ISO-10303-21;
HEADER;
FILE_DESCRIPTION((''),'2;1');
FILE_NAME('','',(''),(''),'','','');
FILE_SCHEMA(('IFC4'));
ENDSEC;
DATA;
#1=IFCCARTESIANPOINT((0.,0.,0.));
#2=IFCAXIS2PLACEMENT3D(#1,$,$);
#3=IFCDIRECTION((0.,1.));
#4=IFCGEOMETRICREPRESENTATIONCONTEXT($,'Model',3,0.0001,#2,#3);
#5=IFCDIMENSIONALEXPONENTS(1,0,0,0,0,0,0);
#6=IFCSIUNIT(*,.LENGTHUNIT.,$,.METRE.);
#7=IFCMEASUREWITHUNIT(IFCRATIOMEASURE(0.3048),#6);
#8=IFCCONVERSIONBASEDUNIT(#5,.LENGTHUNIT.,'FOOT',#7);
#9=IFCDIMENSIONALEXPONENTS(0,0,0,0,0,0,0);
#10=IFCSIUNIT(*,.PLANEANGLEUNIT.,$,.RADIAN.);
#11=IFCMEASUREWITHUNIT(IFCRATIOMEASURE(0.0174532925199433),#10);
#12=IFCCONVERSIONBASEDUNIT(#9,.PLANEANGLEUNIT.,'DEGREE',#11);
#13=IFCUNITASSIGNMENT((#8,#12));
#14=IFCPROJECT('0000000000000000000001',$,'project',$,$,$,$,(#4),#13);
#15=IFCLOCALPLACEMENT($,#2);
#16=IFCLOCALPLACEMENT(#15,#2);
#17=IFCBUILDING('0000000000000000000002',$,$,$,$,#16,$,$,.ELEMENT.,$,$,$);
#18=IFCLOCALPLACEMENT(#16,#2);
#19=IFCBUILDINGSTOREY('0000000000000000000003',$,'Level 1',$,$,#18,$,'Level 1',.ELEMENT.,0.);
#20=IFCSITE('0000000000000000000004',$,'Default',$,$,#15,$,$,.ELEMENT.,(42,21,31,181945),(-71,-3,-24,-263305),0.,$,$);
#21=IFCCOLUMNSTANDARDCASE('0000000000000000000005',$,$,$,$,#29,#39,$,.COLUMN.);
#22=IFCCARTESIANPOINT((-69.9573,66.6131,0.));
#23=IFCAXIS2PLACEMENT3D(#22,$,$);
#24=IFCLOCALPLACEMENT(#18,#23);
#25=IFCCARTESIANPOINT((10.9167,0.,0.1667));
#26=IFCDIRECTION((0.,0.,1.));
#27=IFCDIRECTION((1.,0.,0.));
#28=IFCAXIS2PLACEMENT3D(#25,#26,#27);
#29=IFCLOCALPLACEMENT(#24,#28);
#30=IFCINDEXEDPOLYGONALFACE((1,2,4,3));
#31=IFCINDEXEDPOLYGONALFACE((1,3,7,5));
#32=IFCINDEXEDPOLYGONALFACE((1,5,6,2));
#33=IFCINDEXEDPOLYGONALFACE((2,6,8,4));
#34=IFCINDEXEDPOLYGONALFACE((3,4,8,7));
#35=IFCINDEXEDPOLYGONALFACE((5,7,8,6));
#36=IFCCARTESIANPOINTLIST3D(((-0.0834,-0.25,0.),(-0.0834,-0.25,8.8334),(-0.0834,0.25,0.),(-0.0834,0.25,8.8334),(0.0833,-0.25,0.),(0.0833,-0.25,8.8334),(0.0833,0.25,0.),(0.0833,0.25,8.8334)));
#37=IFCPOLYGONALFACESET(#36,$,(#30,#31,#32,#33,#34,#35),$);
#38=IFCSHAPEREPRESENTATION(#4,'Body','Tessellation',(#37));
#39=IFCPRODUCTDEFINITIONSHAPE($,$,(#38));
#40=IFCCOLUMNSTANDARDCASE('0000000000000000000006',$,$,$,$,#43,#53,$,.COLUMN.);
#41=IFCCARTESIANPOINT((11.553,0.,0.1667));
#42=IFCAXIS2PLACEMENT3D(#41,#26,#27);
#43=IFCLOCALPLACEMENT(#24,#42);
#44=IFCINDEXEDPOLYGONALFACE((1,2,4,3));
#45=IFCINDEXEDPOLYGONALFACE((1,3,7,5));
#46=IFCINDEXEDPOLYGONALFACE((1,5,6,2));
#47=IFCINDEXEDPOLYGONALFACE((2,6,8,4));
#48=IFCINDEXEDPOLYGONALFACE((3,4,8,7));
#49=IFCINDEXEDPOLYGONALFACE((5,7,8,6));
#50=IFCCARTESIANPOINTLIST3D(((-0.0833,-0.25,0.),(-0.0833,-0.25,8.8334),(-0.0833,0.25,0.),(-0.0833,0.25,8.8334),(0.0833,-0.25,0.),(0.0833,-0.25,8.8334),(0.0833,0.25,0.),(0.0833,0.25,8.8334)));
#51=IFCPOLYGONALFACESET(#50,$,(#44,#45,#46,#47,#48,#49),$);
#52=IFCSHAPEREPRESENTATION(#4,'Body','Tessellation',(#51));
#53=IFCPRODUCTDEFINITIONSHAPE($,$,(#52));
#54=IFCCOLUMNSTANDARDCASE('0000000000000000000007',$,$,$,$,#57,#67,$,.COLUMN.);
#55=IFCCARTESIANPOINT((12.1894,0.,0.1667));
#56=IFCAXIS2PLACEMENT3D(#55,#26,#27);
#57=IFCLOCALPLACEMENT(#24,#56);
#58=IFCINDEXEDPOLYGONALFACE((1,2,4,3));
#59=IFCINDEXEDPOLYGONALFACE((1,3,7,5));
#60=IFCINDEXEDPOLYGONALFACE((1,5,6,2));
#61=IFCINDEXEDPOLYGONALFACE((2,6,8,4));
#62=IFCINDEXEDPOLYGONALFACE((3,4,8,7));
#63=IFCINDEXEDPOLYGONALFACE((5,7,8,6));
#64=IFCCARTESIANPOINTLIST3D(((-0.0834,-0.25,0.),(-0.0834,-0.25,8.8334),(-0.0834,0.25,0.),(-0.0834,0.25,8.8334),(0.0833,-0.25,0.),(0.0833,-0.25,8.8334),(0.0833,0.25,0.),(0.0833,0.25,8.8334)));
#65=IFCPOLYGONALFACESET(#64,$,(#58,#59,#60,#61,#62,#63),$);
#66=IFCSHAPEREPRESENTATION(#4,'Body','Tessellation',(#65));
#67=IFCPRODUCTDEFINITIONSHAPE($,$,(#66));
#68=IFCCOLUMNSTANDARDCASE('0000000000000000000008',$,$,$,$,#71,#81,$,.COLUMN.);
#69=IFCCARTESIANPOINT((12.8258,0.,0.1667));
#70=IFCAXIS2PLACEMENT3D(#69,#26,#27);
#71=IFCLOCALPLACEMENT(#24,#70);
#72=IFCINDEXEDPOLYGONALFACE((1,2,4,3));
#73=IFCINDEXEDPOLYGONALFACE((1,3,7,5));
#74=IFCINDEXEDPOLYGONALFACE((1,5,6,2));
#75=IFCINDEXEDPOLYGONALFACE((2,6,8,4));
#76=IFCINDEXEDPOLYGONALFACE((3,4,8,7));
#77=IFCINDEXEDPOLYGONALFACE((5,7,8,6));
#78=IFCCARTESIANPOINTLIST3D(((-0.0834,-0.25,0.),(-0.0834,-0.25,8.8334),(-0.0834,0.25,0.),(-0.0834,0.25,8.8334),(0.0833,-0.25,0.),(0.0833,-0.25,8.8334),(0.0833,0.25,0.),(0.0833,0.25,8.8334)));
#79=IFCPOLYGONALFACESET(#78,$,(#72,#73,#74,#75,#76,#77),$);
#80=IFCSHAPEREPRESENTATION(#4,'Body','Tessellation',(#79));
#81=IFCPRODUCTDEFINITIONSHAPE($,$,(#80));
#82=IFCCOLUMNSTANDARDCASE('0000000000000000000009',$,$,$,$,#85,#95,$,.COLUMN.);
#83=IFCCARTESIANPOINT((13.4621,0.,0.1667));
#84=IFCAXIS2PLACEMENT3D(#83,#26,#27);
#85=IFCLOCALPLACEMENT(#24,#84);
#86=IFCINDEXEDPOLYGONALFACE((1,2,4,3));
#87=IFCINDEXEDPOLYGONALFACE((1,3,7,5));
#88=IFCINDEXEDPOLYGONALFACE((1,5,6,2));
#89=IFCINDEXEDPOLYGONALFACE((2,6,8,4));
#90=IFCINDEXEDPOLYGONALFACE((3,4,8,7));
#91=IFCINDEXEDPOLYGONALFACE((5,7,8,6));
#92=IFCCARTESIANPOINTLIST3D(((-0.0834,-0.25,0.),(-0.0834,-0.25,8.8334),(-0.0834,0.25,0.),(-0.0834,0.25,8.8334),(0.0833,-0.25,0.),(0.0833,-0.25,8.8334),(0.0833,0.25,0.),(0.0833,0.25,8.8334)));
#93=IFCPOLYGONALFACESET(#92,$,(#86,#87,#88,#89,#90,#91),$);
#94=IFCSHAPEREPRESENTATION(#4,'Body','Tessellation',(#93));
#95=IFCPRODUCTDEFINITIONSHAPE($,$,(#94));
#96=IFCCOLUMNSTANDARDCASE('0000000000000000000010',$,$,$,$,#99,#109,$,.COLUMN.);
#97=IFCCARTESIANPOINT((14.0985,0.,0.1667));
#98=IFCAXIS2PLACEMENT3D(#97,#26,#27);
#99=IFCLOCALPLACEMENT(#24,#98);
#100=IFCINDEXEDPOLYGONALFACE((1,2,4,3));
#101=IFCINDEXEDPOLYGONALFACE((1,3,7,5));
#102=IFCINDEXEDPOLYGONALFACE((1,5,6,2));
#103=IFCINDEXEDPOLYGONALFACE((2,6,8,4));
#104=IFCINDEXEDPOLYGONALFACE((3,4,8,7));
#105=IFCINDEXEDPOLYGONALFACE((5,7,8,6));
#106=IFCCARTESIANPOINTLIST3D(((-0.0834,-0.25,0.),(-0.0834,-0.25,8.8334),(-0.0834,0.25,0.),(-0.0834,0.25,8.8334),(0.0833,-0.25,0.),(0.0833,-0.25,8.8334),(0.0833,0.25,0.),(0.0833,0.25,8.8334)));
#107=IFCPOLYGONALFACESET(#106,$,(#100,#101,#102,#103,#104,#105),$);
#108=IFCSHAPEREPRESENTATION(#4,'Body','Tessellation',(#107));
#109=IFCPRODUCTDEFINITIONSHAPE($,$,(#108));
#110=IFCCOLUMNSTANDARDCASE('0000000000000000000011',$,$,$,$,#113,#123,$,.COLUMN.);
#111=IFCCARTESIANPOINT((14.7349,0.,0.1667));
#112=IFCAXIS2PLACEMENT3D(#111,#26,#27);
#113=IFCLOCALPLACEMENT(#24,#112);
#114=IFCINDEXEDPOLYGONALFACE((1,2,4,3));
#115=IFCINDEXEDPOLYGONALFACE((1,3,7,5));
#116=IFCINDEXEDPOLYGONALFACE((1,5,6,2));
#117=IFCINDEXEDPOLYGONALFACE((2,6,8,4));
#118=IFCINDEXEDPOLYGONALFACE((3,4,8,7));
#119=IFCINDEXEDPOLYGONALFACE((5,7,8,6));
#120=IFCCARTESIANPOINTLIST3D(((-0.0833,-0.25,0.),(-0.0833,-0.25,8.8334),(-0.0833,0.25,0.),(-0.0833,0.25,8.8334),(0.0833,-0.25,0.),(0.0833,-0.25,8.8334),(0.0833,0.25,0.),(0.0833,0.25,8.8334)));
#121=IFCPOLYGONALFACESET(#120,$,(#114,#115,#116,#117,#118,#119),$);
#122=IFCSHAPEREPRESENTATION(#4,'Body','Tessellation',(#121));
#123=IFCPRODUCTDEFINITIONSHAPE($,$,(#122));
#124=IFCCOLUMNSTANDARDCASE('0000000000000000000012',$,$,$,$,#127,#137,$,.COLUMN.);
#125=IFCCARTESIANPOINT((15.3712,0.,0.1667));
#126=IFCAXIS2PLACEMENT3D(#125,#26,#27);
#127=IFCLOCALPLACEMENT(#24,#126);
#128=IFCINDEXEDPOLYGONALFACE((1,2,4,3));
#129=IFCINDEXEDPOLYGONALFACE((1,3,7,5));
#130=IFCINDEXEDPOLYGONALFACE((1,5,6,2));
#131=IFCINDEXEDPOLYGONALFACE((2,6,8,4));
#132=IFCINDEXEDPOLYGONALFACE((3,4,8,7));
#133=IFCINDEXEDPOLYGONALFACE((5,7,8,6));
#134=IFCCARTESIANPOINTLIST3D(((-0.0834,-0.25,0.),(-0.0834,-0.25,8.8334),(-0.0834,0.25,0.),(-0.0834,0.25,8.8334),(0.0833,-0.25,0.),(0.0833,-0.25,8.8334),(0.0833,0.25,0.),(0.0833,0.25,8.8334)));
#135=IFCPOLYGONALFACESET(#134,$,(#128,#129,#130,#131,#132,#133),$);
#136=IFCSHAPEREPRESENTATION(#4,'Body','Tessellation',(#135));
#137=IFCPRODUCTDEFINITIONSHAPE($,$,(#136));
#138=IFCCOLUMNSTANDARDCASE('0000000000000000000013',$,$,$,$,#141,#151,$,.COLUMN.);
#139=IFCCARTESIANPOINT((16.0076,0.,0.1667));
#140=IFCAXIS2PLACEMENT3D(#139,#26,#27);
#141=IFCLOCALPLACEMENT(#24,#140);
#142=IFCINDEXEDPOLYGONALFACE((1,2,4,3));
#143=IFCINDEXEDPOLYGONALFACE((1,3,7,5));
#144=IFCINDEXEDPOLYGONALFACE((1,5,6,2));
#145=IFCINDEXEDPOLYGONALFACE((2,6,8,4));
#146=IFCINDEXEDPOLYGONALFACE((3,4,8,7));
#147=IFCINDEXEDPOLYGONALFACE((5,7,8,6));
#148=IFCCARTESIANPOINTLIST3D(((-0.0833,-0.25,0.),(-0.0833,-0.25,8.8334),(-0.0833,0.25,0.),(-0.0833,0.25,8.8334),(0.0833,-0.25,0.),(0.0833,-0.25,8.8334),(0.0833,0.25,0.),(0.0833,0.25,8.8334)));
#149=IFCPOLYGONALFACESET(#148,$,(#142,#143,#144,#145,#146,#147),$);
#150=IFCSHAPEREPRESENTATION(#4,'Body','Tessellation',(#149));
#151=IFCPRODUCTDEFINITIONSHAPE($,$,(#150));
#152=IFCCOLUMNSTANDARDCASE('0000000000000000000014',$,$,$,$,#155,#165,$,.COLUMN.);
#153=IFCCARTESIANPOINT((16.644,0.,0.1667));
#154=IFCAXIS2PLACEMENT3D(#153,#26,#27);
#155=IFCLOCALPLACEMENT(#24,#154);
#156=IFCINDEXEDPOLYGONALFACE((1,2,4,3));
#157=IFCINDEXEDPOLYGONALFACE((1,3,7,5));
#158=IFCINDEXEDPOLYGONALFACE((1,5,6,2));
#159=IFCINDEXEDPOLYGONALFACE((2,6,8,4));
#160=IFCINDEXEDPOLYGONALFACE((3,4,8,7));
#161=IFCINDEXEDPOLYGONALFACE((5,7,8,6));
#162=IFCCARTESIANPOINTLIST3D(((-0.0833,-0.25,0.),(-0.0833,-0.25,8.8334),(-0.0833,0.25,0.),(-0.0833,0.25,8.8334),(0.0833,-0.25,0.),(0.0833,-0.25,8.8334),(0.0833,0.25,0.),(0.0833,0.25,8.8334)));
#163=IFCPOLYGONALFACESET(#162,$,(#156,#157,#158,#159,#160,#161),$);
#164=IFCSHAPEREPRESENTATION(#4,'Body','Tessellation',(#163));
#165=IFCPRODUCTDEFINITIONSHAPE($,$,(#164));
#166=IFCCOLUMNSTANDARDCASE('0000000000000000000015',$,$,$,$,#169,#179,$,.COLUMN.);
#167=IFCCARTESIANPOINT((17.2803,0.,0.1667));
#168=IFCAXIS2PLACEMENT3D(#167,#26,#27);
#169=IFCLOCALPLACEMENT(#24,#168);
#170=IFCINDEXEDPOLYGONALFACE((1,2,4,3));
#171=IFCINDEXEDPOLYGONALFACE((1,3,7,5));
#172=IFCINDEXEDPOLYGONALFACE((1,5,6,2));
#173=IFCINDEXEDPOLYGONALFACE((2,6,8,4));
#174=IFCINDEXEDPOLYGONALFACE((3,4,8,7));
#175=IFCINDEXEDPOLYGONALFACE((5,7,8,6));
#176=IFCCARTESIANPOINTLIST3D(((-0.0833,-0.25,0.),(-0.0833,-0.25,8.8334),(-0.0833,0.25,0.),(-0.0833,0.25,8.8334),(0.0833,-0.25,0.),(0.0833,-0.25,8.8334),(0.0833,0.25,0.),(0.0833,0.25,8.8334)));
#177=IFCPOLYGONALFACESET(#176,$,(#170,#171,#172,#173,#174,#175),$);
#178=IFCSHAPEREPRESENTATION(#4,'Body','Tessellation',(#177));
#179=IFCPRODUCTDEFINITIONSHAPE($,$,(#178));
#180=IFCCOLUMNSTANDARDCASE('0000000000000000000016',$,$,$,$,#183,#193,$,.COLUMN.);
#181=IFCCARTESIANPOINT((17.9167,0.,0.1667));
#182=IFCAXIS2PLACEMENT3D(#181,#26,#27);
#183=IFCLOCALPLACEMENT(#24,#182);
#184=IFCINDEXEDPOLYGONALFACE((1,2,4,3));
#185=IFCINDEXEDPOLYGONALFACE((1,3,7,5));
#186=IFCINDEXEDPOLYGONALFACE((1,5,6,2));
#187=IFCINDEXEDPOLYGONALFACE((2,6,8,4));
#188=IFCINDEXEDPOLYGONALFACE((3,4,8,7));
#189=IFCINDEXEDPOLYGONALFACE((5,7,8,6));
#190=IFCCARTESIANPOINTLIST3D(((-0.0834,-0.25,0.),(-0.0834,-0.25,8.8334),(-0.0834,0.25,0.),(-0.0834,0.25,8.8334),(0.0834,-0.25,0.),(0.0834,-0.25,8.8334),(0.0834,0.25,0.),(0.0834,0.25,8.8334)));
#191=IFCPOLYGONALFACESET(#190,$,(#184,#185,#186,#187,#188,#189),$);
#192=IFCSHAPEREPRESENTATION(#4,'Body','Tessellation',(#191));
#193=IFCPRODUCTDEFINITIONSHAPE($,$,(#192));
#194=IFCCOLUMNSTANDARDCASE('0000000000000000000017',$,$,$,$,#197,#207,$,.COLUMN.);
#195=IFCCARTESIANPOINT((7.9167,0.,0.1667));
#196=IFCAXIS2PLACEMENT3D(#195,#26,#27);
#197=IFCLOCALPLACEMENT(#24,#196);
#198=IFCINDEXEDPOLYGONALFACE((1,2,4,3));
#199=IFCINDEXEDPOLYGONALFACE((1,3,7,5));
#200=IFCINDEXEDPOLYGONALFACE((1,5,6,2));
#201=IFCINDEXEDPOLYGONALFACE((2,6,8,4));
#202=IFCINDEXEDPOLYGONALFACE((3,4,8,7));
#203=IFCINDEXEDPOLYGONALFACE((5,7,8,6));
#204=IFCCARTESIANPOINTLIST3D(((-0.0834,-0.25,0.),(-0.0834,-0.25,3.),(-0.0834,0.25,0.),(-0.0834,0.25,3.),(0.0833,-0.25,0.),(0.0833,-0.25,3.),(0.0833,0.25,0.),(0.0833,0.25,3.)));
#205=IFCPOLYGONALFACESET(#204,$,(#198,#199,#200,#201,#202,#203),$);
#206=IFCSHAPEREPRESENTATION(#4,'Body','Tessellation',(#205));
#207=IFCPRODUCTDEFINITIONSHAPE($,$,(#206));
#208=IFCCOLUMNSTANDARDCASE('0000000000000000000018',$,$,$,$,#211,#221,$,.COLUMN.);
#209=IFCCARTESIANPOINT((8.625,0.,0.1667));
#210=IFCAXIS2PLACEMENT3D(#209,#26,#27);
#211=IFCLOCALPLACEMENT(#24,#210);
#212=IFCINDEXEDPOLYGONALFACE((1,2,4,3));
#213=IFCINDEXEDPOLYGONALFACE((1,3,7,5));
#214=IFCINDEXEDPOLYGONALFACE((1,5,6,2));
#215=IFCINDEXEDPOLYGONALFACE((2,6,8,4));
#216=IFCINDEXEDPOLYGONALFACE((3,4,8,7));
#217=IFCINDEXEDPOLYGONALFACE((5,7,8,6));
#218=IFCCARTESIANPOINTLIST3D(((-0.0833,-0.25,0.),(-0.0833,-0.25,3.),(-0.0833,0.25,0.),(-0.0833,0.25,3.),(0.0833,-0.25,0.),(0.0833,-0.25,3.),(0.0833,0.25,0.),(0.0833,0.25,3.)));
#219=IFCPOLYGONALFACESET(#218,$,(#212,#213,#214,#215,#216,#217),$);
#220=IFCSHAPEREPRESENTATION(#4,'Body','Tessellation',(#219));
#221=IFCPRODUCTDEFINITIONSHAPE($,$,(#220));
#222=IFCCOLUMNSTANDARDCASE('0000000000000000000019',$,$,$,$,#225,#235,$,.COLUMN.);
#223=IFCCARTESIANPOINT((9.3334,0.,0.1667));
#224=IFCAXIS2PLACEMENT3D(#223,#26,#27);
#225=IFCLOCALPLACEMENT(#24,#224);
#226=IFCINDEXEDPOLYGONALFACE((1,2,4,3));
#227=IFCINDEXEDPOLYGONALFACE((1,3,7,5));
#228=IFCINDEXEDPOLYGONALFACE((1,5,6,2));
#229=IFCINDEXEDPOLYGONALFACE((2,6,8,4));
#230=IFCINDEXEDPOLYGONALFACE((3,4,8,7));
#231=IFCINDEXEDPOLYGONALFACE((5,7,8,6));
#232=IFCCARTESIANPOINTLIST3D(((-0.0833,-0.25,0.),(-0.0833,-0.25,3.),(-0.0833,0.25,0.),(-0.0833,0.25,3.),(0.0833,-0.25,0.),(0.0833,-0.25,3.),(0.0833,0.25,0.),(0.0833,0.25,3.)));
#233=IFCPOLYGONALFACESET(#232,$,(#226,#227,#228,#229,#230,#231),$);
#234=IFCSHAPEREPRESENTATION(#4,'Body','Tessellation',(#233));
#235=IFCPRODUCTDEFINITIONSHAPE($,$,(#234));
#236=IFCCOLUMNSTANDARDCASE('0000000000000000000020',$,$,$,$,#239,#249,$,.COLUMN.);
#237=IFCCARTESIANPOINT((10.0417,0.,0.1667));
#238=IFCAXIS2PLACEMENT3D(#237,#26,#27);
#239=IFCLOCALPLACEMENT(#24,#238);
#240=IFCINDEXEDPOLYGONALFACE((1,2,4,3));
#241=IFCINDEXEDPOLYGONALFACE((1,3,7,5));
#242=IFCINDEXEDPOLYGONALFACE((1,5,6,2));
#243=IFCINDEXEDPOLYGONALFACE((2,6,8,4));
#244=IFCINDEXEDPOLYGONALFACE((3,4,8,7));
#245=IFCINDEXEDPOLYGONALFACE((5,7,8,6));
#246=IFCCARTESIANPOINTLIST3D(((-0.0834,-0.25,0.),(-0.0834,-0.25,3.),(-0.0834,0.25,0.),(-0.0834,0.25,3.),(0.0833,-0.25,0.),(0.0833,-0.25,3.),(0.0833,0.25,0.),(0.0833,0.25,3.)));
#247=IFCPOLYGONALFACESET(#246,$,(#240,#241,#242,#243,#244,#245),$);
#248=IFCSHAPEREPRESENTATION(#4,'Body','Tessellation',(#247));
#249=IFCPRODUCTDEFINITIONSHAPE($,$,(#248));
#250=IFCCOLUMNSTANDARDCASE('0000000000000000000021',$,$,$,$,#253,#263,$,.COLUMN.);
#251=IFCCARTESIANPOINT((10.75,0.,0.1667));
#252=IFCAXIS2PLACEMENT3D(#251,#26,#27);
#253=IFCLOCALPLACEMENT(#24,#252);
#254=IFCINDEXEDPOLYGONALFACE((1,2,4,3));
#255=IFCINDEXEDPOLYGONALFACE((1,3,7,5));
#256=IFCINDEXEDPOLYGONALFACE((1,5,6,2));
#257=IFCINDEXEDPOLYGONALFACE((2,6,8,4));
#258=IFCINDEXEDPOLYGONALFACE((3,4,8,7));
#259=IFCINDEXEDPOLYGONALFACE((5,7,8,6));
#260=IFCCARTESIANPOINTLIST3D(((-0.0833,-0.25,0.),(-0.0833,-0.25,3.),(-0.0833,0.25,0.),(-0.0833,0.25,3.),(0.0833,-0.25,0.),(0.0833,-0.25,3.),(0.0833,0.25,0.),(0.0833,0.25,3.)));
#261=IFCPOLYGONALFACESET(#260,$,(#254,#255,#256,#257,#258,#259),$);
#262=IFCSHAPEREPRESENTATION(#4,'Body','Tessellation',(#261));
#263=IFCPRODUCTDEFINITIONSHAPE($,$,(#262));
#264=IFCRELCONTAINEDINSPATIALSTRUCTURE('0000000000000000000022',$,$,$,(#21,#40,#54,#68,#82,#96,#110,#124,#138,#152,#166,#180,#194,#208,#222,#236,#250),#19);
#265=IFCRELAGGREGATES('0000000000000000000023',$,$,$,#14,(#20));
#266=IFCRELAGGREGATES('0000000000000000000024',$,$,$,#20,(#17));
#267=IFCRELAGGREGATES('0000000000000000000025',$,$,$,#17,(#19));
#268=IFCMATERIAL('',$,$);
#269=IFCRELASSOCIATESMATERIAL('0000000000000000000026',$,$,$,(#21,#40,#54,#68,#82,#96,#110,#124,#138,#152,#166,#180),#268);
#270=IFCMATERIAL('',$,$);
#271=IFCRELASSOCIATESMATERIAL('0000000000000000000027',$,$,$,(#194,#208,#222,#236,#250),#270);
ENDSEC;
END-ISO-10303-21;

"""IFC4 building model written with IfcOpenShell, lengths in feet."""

from ifc_helpers import new_model, entity, si_unit, converted_unit, direction, frame, origin, place, context, project, spatial, rectangle, extrude, material, element, save


model = new_model("IFC4")

# Units and contexts
model_context = context("Model", 3, precision=0.0001, world=origin(), true_north=direction((0.0, 1.0)))
ifc_project = project(units=[converted_unit("LENGTHUNIT", "FOOT", entity("IfcRatioMeasure", 0.3048), si_unit("LENGTHUNIT", "METRE"), dimensions=[1, 0, 0, 0, 0, 0, 0]), converted_unit("PLANEANGLEUNIT", "DEGREE", entity("IfcRatioMeasure", 0.0174532925199433), si_unit("PLANEANGLEUNIT", "RADIAN"), dimensions=[0, 0, 0, 0, 0, 0, 0])], contexts=[model_context])

# Site, building, storey
site_placement = place(None, origin())
site = spatial("IfcSite", under=ifc_project, at=site_placement, Name="Default", CompositionType="ELEMENT", RefLatitude=(42, 21, 31, 181945), RefLongitude=(-71, -3, -24, -263305), RefElevation=0.0)
building_placement = place(site_placement, origin())
building = spatial("IfcBuilding", under=site, at=building_placement, CompositionType="ELEMENT")
storey_placement = place(building_placement, origin())
storey = spatial("IfcBuildingStorey", under=building, at=storey_placement, Name="Level 1", LongName="Level 1", CompositionType="ELEMENT", Elevation=0.0)

# Columns
placement_1 = place(storey_placement, frame((-69.9573, 66.6131, 0.0)))
ifc_material_1 = material(Name="")
for number, where, z_axis, x_axis in (
    (1, (10.9167, 0.0, 0.1667), (0.0, 0.0, 1.0), (1.0, 0.0, 0.0)),
    (2, (11.553, 0.0, 0.1667), (0.0, 0.0, 1.0), (1.0, 0.0, 0.0)),
    (3, (12.1894, 0.0, 0.1667), (0.0, 0.0, 1.0), (1.0, 0.0, 0.0)),
    (4, (12.8258, 0.0, 0.1667), (0.0, 0.0, 1.0), (1.0, 0.0, 0.0)),
    (5, (13.4621, 0.0, 0.1667), (0.0, 0.0, 1.0), (1.0, 0.0, 0.0)),
    (6, (14.0985, 0.0, 0.1667), (0.0, 0.0, 1.0), (1.0, 0.0, 0.0)),
    (7, (14.7349, 0.0, 0.1667), (0.0, 0.0, 1.0), (1.0, 0.0, 0.0)),
    (8, (15.3712, 0.0, 0.1667), (0.0, 0.0, 1.0), (1.0, 0.0, 0.0)),
    (9, (16.0076, 0.0, 0.1667), (0.0, 0.0, 1.0), (1.0, 0.0, 0.0)),
    (10, (16.644, 0.0, 0.1667), (0.0, 0.0, 1.0), (1.0, 0.0, 0.0)),
    (11, (17.2803, 0.0, 0.1667), (0.0, 0.0, 1.0), (1.0, 0.0, 0.0)),
    (12, (17.9167, 0.0, 0.1667), (0.0, 0.0, 1.0), (1.0, 0.0, 0.0)),
):
    element("IfcColumnStandardCase", number, at=place(placement_1, frame(where, z_axis=z_axis, x_axis=x_axis)), inside=storey, material=ifc_material_1, PredefinedType="COLUMN", context=model_context, shape_type="SweptSolid", body=[
        extrude(rectangle(XDim=0.1667, YDim=0.5), origin(), (0.0, 0.0, 1.0), 8.8334),
    ])
ifc_material_2 = material(Name="")
for number, where, z_axis, x_axis in (
    (13, (7.9167, 0.0, 0.1667), (0.0, 0.0, 1.0), (1.0, 0.0, 0.0)),
    (14, (8.625, 0.0, 0.1667), (0.0, 0.0, 1.0), (1.0, 0.0, 0.0)),
    (15, (9.3334, 0.0, 0.1667), (0.0, 0.0, 1.0), (1.0, 0.0, 0.0)),
    (16, (10.0417, 0.0, 0.1667), (0.0, 0.0, 1.0), (1.0, 0.0, 0.0)),
    (17, (10.75, 0.0, 0.1667), (0.0, 0.0, 1.0), (1.0, 0.0, 0.0)),
):
    element("IfcColumnStandardCase", number, at=place(placement_1, frame(where, z_axis=z_axis, x_axis=x_axis)), inside=storey, material=ifc_material_2, PredefinedType="COLUMN", context=model_context, shape_type="SweptSolid", body=[
        extrude(rectangle(XDim=0.1667, YDim=0.5), origin(), (0.0, 0.0, 1.0), 3.0),
    ])

save(model, "model.ifc")
